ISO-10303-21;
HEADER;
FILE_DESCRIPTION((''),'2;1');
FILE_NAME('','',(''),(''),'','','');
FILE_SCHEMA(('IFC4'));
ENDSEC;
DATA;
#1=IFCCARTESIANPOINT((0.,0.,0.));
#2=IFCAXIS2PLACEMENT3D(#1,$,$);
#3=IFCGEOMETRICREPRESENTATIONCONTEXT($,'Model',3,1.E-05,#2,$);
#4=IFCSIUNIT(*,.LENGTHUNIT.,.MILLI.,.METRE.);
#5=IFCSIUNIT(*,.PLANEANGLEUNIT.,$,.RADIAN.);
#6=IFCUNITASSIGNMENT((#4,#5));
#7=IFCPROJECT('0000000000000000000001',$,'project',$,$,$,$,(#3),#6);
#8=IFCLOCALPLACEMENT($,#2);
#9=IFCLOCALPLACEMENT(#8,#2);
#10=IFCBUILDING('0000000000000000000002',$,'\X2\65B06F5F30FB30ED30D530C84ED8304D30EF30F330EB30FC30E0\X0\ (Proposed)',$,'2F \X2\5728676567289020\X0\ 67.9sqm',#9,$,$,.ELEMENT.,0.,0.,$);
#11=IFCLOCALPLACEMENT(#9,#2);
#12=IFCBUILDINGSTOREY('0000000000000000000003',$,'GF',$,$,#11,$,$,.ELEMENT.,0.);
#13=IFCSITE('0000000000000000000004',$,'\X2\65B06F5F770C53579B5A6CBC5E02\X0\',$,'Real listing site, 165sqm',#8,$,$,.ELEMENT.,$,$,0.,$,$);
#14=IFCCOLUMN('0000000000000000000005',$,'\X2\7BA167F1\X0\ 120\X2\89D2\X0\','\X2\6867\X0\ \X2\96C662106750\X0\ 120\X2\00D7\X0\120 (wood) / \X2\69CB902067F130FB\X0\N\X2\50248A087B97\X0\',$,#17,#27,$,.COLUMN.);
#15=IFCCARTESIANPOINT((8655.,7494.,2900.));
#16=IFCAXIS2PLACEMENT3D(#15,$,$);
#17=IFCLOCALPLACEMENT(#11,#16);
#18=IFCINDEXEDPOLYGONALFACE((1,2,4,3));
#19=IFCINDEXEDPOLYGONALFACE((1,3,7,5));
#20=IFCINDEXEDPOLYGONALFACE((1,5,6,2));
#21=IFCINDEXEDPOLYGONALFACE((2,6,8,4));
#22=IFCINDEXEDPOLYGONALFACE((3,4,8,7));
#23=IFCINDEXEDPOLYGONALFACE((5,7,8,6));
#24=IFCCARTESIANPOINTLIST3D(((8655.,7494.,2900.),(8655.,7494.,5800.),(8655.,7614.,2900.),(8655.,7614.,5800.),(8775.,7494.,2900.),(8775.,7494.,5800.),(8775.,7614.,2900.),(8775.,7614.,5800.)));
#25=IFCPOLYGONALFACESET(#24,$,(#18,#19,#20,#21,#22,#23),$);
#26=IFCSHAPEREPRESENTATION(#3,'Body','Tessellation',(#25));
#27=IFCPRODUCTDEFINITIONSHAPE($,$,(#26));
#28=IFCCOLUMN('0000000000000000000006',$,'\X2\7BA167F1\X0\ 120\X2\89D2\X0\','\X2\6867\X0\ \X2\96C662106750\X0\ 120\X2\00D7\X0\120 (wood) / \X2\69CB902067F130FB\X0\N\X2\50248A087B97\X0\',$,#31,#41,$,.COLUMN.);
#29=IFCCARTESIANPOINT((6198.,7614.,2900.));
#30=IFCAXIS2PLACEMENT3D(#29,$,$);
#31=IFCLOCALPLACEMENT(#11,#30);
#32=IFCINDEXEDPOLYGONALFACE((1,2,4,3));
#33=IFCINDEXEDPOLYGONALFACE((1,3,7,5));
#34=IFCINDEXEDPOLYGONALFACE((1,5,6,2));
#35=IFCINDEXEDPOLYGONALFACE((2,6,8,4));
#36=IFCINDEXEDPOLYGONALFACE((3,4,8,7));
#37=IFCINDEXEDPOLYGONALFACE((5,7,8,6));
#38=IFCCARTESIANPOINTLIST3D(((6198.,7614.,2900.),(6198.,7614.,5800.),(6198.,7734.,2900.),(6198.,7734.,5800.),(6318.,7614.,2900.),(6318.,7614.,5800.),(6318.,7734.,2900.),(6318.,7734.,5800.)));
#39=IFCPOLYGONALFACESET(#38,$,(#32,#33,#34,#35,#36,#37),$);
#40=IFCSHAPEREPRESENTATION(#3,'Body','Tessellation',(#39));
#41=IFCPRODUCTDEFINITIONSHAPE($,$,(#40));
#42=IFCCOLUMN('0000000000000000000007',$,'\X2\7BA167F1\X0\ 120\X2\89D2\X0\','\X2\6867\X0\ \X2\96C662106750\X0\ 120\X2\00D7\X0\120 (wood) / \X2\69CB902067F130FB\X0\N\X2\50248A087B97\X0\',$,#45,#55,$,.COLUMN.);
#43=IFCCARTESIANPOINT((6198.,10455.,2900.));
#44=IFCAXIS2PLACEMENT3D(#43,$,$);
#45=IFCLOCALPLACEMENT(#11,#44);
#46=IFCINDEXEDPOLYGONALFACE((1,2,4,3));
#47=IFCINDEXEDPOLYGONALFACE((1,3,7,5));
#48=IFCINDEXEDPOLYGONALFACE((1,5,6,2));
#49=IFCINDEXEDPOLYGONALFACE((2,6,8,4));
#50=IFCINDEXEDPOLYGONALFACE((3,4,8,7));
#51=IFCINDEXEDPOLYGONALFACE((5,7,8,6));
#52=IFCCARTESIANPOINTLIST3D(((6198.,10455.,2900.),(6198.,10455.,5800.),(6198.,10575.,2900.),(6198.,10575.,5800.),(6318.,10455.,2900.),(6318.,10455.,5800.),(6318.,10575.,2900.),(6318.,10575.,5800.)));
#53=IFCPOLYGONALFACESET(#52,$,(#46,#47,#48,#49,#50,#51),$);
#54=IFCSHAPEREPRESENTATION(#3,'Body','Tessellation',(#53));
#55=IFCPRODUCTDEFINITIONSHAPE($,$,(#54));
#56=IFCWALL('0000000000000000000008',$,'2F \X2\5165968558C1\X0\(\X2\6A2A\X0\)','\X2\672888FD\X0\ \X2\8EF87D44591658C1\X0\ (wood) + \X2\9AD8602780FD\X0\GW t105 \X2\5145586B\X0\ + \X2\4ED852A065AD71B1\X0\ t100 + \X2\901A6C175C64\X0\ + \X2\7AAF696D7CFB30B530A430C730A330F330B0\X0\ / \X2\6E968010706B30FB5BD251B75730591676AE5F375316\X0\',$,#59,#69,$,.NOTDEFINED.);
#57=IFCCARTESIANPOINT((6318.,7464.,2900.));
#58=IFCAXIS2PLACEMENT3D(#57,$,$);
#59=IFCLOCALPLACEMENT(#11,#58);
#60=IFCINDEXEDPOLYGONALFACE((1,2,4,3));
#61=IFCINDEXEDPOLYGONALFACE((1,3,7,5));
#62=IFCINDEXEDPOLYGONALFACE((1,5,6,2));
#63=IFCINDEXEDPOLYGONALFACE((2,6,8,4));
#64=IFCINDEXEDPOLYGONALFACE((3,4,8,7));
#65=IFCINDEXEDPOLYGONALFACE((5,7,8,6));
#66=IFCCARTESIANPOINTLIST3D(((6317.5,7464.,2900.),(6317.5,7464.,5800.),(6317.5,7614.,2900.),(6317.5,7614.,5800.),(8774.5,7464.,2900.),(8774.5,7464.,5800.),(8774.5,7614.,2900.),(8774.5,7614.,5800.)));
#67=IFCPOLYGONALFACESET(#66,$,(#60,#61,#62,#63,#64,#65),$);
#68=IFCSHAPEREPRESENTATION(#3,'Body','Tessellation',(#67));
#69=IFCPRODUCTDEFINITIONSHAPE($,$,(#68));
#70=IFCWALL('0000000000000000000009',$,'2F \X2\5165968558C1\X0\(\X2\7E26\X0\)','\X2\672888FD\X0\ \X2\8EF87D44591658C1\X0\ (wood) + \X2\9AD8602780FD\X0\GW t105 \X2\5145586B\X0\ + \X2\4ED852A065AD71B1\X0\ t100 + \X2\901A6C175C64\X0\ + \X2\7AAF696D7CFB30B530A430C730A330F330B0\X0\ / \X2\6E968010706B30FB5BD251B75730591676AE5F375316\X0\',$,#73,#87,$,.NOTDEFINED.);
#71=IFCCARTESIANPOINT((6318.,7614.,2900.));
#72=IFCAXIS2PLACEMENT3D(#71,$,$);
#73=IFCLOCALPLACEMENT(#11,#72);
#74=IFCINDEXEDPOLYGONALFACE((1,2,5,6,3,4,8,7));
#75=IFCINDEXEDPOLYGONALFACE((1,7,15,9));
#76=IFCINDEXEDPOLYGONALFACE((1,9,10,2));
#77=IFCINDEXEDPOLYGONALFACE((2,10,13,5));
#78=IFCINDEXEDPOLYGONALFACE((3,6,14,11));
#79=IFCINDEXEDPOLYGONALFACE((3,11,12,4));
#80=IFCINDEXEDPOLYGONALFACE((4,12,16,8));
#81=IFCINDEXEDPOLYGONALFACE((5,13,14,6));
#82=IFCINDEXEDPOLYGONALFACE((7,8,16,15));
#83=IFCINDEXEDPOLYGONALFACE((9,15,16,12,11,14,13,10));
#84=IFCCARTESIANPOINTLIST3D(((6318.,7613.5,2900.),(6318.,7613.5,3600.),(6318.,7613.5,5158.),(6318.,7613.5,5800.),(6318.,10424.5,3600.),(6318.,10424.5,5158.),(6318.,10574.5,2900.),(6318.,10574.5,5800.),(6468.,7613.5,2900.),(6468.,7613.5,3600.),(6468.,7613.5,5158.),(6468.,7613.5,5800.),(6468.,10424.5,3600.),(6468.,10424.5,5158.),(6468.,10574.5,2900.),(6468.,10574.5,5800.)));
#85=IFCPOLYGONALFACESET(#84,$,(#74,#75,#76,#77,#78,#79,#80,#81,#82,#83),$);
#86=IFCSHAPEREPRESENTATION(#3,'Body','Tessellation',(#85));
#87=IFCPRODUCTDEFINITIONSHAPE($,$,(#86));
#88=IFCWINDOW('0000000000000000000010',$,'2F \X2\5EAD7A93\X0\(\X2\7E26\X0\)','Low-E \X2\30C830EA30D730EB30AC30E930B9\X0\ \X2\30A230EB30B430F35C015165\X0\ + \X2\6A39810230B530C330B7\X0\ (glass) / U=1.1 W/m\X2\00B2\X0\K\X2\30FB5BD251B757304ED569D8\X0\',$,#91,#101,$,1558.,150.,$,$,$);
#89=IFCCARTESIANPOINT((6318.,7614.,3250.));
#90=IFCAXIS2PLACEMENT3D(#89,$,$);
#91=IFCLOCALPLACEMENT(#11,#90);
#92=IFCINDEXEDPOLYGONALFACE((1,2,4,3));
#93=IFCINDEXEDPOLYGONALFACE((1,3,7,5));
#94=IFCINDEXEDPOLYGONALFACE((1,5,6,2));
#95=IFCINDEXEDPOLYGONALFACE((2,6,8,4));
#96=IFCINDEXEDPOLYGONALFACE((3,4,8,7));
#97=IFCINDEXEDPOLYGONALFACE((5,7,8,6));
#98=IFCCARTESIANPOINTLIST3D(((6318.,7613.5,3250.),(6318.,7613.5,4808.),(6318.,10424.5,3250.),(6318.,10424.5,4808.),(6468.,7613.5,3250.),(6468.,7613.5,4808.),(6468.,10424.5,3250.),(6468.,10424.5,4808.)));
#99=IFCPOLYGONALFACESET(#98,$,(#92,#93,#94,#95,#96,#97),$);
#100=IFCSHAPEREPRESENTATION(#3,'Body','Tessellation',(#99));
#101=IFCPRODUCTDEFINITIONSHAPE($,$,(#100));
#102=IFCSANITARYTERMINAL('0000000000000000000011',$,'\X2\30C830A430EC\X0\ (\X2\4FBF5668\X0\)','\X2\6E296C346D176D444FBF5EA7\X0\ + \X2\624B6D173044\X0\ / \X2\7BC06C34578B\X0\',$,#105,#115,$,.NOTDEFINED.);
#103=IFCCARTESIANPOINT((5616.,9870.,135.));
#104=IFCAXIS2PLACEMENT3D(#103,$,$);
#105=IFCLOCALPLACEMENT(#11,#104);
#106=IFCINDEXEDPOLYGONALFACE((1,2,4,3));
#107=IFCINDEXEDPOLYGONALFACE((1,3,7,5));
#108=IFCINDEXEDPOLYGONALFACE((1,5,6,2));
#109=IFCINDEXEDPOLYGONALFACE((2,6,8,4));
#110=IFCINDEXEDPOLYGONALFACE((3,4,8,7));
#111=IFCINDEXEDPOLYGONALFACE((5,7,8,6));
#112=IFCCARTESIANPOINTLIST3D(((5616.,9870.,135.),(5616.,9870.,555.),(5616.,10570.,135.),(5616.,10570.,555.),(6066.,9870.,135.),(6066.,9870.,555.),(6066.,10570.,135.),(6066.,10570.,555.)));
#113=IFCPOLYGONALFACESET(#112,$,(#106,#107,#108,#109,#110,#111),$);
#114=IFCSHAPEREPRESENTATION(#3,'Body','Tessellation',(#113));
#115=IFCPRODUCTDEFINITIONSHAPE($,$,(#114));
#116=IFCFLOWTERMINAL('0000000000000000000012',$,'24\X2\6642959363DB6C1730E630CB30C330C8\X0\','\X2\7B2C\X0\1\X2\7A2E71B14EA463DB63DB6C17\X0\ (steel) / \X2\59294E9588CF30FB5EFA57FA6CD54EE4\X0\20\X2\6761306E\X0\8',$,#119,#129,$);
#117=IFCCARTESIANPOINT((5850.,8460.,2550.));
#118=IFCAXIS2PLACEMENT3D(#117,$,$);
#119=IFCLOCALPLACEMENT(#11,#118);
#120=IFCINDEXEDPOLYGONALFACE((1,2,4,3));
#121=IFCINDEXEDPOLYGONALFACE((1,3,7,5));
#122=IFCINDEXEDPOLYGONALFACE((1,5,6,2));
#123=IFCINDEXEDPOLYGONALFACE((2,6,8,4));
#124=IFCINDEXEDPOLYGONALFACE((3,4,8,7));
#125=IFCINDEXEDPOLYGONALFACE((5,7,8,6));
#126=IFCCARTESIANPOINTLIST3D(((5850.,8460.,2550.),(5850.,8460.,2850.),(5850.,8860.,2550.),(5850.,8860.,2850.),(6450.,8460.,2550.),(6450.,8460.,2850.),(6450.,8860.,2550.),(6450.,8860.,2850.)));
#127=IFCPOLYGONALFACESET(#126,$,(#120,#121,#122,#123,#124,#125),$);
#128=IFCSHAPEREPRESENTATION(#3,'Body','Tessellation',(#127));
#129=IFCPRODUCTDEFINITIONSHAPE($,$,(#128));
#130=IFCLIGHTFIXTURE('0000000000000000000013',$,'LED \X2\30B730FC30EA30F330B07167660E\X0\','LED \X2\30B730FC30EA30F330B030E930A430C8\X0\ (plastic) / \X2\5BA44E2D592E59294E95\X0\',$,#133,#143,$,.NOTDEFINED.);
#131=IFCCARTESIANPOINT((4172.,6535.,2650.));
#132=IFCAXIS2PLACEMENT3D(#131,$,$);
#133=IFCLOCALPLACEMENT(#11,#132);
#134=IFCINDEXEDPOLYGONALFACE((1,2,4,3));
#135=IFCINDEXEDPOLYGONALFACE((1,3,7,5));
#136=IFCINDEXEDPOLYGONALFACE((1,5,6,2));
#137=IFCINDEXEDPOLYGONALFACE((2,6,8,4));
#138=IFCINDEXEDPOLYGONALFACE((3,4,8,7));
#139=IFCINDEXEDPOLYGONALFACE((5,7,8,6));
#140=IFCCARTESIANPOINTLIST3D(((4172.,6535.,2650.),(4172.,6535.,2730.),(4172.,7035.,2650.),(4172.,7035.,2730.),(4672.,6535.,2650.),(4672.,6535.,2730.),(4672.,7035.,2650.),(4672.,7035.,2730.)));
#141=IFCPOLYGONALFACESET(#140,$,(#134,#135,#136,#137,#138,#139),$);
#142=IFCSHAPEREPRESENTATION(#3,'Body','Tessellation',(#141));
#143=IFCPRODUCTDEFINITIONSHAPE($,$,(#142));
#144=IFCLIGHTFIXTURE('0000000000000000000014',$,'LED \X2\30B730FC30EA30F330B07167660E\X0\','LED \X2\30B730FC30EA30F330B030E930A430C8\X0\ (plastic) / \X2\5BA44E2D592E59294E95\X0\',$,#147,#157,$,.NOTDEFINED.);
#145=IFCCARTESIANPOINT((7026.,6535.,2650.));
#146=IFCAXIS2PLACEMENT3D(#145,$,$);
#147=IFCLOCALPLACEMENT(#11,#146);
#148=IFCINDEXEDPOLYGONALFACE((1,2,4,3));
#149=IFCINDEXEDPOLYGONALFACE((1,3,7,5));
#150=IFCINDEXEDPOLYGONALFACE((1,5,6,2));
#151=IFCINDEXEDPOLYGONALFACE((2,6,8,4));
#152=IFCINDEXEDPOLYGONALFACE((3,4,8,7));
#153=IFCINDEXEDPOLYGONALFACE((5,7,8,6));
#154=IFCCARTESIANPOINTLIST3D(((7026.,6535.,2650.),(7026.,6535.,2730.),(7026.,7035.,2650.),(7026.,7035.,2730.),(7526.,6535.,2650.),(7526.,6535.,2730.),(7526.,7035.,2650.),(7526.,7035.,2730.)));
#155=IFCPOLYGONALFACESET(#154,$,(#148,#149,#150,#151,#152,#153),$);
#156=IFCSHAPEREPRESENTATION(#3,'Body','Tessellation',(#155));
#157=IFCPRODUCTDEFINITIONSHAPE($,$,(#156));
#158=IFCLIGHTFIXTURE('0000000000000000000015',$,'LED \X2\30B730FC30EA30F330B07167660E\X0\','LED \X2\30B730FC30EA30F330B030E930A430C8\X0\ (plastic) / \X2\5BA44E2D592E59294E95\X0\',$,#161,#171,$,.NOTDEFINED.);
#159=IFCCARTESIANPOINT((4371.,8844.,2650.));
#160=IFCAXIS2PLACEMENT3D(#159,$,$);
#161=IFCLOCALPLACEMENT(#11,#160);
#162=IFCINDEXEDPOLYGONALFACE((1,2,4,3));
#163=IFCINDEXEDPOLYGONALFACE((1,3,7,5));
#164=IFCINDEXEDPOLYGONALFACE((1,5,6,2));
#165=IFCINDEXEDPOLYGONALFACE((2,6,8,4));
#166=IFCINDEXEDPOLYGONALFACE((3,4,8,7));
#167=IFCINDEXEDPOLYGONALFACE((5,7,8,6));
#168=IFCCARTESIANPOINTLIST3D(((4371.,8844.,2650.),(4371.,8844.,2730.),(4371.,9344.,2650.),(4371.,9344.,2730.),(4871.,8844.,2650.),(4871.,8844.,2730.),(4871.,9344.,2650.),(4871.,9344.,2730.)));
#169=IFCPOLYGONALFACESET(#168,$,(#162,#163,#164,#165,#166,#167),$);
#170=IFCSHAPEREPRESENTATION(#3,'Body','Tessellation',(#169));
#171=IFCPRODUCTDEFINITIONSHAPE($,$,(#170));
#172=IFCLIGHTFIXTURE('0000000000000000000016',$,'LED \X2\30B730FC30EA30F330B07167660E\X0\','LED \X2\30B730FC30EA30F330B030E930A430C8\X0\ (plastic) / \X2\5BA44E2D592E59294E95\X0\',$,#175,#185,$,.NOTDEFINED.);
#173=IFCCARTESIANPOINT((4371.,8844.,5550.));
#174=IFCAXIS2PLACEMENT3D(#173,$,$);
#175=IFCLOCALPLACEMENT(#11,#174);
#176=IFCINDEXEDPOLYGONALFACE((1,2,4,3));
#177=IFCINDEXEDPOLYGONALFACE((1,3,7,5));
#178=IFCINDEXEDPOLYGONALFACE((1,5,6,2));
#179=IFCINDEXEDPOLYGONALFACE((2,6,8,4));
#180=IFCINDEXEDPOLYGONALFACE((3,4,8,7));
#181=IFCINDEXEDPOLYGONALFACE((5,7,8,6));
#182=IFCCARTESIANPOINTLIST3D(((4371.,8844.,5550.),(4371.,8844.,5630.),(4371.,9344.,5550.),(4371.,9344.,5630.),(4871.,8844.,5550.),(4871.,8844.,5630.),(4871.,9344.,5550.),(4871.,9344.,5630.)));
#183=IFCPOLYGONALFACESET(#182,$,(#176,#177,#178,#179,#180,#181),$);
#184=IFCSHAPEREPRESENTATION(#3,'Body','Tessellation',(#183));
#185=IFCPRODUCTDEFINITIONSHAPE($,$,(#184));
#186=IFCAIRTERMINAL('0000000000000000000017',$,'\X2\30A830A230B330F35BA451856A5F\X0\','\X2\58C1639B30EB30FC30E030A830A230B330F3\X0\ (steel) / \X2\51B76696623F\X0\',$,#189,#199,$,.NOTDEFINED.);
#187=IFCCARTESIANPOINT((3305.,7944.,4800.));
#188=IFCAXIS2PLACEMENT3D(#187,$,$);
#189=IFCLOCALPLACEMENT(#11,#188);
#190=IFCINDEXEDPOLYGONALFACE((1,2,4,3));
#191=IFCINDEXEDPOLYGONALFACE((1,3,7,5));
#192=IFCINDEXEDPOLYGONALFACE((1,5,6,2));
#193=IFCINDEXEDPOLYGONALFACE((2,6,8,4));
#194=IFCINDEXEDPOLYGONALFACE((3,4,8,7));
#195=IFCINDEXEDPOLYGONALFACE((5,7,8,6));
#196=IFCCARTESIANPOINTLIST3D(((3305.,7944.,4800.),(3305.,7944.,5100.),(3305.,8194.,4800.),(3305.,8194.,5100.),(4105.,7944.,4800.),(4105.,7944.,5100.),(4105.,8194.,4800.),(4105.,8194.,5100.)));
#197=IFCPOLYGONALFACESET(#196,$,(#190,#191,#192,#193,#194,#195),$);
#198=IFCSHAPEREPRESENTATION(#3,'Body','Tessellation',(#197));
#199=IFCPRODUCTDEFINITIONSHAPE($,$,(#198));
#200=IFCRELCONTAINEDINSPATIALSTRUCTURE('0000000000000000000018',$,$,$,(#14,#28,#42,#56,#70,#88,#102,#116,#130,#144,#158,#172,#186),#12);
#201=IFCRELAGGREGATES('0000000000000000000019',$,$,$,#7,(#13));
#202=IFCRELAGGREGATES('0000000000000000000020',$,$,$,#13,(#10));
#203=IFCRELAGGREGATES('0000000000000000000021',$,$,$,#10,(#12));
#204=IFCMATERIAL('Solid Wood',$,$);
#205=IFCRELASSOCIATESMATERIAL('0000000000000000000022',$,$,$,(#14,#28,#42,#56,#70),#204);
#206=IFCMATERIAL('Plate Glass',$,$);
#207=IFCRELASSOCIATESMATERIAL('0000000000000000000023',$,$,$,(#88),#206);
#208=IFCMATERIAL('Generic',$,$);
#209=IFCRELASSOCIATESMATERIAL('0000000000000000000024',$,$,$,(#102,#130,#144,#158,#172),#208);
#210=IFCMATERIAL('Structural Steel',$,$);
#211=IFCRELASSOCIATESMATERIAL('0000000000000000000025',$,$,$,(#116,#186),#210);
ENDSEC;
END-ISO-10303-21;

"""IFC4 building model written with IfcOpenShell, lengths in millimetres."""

from ifc_helpers import new_model, si_unit, frame, frame_2d, origin, place, context, project, spatial, rectangle, extrude, material, element, fill, save


model = new_model("IFC4")

# Units and contexts
model_context = context("Model", 3, precision=1e-05, world=origin())
ifc_project = project(units=[si_unit("LENGTHUNIT", "METRE", prefix="MILLI"), si_unit("PLANEANGLEUNIT", "RADIAN")], contexts=[model_context])

# Site, building, storey
site_placement = place(None, origin())
site = spatial("IfcSite", under=ifc_project, at=site_placement, Name="新潟県南魚沼市", ObjectType="Real listing site, 165sqm", CompositionType="ELEMENT", RefElevation=0.0)
building_placement = place(site_placement, origin())
building = spatial("IfcBuilding", under=site, at=building_placement, Name="新潟・ロフト付きワンルーム (Proposed)", ObjectType="2F 在来木造 67.9sqm", CompositionType="ELEMENT", ElevationOfRefHeight=0.0, ElevationOfTerrain=0.0)
storey_placement = place(building_placement, origin())
storey = spatial("IfcBuildingStorey", under=building, at=storey_placement, Name="GF", CompositionType="ELEMENT", Elevation=0.0)

# Columns
ifc_material_1 = material(Name="Solid Wood")
column_1_placement = place(storey_placement, frame((8655.0, 7494.0, 2900.0)))
element("IfcColumn", 1, at=column_1_placement, inside=storey, material=ifc_material_1, Name="管柱 120角", Description="桧 集成材 120×120 (wood) / 構造柱・N値計算", PredefinedType="COLUMN", context=model_context, shape_type="SweptSolid", body=[
    extrude(rectangle(XDim=120.0, YDim=120.0, at=frame_2d((60.0, 60.0))), frame((8655.0, 7494.0, 2900.0)), (0.0, 0.0, 1.0), 2900.0),
])
column_2_placement = place(storey_placement, frame((6198.0, 7614.0, 2900.0)))
element("IfcColumn", 2, at=column_2_placement, inside=storey, material=ifc_material_1, Name="管柱 120角", Description="桧 集成材 120×120 (wood) / 構造柱・N値計算", PredefinedType="COLUMN", context=model_context, shape_type="SweptSolid", body=[
    extrude(rectangle(XDim=120.0, YDim=120.0, at=frame_2d((60.0, 60.0))), frame((6198.0, 7614.0, 2900.0)), (0.0, 0.0, 1.0), 2900.0),
])
column_3_placement = place(storey_placement, frame((6198.0, 10455.0, 2900.0)))
element("IfcColumn", 3, at=column_3_placement, inside=storey, material=ifc_material_1, Name="管柱 120角", Description="桧 集成材 120×120 (wood) / 構造柱・N値計算", PredefinedType="COLUMN", context=model_context, shape_type="SweptSolid", body=[
    extrude(rectangle(XDim=120.0, YDim=120.0, at=frame_2d((60.0, 60.0))), frame((6198.0, 10455.0, 2900.0)), (0.0, 0.0, 1.0), 2900.0),
])

# Wall
wall_1_placement = place(storey_placement, frame((6318.0, 7464.0, 2900.0)))
element("IfcWall", 4, at=wall_1_placement, inside=storey, material=ifc_material_1, Name="2F 入隅壁(横)", Description="木製 軸組外壁 (wood) + 高性能GW t105 充填 + 付加断熱 t100 + 通気層 + 窯業系サイディング / 準耐火・寒冷地外皮強化", PredefinedType="NOTDEFINED", context=model_context, shape_type="SweptSolid", body=[
    extrude(rectangle(XDim=2457.0, YDim=150.0, at=frame_2d((1228.0, 75.0))), frame((6318.0, 7464.0, 2900.0)), (0.0, 0.0, 1.0), 2900.0),
])

# Wall, opening, window
wall_2_placement = place(storey_placement, frame((6318.0, 7614.0, 2900.0)))
wall_2 = element("IfcWall", 5, at=wall_2_placement, inside=storey, material=ifc_material_1, Name="2F 入隅壁(縦)", Description="木製 軸組外壁 (wood) + 高性能GW t105 充填 + 付加断熱 t100 + 通気層 + 窯業系サイディング / 準耐火・寒冷地外皮強化", PredefinedType="NOTDEFINED", context=model_context, shape_type="SweptSolid", body=[
    extrude(rectangle(XDim=150.0, YDim=2961.0, at=frame_2d((75.0, 1480.0))), frame((6318.0, 7614.0, 2900.0)), (0.0, 0.0, 1.0), 2900.0),
])
opening_placement = place(storey_placement, frame((6318.0, 7614.0, 3250.0)))
opening = element("IfcOpeningElement", 6, at=opening_placement, cuts=wall_2, PredefinedType="NOTDEFINED", context=model_context, shape_type="SweptSolid", body=[
    extrude(rectangle(XDim=150.0, YDim=2811.0, at=frame_2d((75.0, 1405.0))), frame((6318.0, 7614.0, 3250.0)), (0.0, 0.0, 1.0), 1558.0),
])
ifc_material_2 = material(Name="Plate Glass")
window_placement = place(storey_placement, frame((6318.0, 7614.0, 3250.0)))
window = element("IfcWindow", 7, at=window_placement, inside=storey, material=ifc_material_2, Name="2F 庭窓(縦)", Description="Low-E トリプルガラス アルゴン封入 + 樹脂サッシ (glass) / U=1.1 W/m²K・寒冷地仕様", OverallHeight=1558.0, OverallWidth=150.0, context=model_context, shape_type="SweptSolid", body=[
    extrude(rectangle(XDim=150.0, YDim=2811.0, at=frame_2d((75.0, 1405.0))), frame((6318.0, 7614.0, 3250.0)), (0.0, 0.0, 1.0), 1558.0),
])
fill(opening, window)

# Sanitary terminal
ifc_material_3 = material(Name="Generic")
sanitary_terminal_placement = place(storey_placement, frame((5616.0, 9870.0, 135.0)))
element("IfcSanitaryTerminal", 8, at=sanitary_terminal_placement, inside=storey, material=ifc_material_3, Name="トイレ (便器)", Description="温水洗浄便座 + 手洗い / 節水型", PredefinedType="NOTDEFINED", context=model_context, shape_type="SweptSolid", body=[
    extrude(rectangle(XDim=450.0, YDim=700.0, at=frame_2d((225.0, 350.0))), frame((5616.0, 9870.0, 135.0)), (0.0, 0.0, 1.0), 420.0),
])

# Flow terminal
ifc_material_4 = material(Name="Structural Steel")
flow_terminal_placement = place(storey_placement, frame((5850.0, 8460.0, 2550.0)))
element("IfcFlowTerminal", 9, at=flow_terminal_placement, inside=storey, material=ifc_material_4, Name="24時間換気ユニット", Description="第1種熱交換換気 (steel) / 天井裏・建基法令20条の8", context=model_context, shape_type="SweptSolid", body=[
    extrude(rectangle(XDim=600.0, YDim=400.0, at=frame_2d((300.0, 200.0))), frame((5850.0, 8460.0, 2550.0)), (0.0, 0.0, 1.0), 300.0),
])

# Light fixtures
light_fixture_1_placement = place(storey_placement, frame((4172.0, 6535.0, 2650.0)))
element("IfcLightFixture", 10, at=light_fixture_1_placement, inside=storey, material=ifc_material_3, Name="LED シーリング照明", Description="LED シーリングライト (plastic) / 室中央天井", PredefinedType="NOTDEFINED", context=model_context, shape_type="SweptSolid", body=[
    extrude(rectangle(XDim=500.0, YDim=500.0, at=frame_2d((250.0, 250.0))), frame((4172.0, 6535.0, 2650.0)), (0.0, 0.0, 1.0), 80.0),
])
light_fixture_2_placement = place(storey_placement, frame((7026.0, 6535.0, 2650.0)))
element("IfcLightFixture", 11, at=light_fixture_2_placement, inside=storey, material=ifc_material_3, Name="LED シーリング照明", Description="LED シーリングライト (plastic) / 室中央天井", PredefinedType="NOTDEFINED", context=model_context, shape_type="SweptSolid", body=[
    extrude(rectangle(XDim=500.0, YDim=500.0, at=frame_2d((250.0, 250.0))), frame((7026.0, 6535.0, 2650.0)), (0.0, 0.0, 1.0), 80.0),
])
light_fixture_3_placement = place(storey_placement, frame((4371.0, 8844.0, 2650.0)))
element("IfcLightFixture", 12, at=light_fixture_3_placement, inside=storey, material=ifc_material_3, Name="LED シーリング照明", Description="LED シーリングライト (plastic) / 室中央天井", PredefinedType="NOTDEFINED", context=model_context, shape_type="SweptSolid", body=[
    extrude(rectangle(XDim=500.0, YDim=500.0, at=frame_2d((250.0, 250.0))), frame((4371.0, 8844.0, 2650.0)), (0.0, 0.0, 1.0), 80.0),
])
light_fixture_4_placement = place(storey_placement, frame((4371.0, 8844.0, 5550.0)))
element("IfcLightFixture", 13, at=light_fixture_4_placement, inside=storey, material=ifc_material_3, Name="LED シーリング照明", Description="LED シーリングライト (plastic) / 室中央天井", PredefinedType="NOTDEFINED", context=model_context, shape_type="SweptSolid", body=[
    extrude(rectangle(XDim=500.0, YDim=500.0, at=frame_2d((250.0, 250.0))), frame((4371.0, 8844.0, 5550.0)), (0.0, 0.0, 1.0), 80.0),
])

# Air terminal
air_terminal_placement = place(storey_placement, frame((3305.0, 7944.0, 4800.0)))
element("IfcAirTerminal", 14, at=air_terminal_placement, inside=storey, material=ifc_material_4, Name="エアコン室内機", Description="壁掛ルームエアコン (steel) / 冷暖房", PredefinedType="NOTDEFINED", context=model_context, shape_type="SweptSolid", body=[
    extrude(rectangle(XDim=800.0, YDim=250.0, at=frame_2d((400.0, 125.0))), frame((3305.0, 7944.0, 4800.0)), (0.0, 0.0, 1.0), 300.0),
])

save(model, "model.ifc")
